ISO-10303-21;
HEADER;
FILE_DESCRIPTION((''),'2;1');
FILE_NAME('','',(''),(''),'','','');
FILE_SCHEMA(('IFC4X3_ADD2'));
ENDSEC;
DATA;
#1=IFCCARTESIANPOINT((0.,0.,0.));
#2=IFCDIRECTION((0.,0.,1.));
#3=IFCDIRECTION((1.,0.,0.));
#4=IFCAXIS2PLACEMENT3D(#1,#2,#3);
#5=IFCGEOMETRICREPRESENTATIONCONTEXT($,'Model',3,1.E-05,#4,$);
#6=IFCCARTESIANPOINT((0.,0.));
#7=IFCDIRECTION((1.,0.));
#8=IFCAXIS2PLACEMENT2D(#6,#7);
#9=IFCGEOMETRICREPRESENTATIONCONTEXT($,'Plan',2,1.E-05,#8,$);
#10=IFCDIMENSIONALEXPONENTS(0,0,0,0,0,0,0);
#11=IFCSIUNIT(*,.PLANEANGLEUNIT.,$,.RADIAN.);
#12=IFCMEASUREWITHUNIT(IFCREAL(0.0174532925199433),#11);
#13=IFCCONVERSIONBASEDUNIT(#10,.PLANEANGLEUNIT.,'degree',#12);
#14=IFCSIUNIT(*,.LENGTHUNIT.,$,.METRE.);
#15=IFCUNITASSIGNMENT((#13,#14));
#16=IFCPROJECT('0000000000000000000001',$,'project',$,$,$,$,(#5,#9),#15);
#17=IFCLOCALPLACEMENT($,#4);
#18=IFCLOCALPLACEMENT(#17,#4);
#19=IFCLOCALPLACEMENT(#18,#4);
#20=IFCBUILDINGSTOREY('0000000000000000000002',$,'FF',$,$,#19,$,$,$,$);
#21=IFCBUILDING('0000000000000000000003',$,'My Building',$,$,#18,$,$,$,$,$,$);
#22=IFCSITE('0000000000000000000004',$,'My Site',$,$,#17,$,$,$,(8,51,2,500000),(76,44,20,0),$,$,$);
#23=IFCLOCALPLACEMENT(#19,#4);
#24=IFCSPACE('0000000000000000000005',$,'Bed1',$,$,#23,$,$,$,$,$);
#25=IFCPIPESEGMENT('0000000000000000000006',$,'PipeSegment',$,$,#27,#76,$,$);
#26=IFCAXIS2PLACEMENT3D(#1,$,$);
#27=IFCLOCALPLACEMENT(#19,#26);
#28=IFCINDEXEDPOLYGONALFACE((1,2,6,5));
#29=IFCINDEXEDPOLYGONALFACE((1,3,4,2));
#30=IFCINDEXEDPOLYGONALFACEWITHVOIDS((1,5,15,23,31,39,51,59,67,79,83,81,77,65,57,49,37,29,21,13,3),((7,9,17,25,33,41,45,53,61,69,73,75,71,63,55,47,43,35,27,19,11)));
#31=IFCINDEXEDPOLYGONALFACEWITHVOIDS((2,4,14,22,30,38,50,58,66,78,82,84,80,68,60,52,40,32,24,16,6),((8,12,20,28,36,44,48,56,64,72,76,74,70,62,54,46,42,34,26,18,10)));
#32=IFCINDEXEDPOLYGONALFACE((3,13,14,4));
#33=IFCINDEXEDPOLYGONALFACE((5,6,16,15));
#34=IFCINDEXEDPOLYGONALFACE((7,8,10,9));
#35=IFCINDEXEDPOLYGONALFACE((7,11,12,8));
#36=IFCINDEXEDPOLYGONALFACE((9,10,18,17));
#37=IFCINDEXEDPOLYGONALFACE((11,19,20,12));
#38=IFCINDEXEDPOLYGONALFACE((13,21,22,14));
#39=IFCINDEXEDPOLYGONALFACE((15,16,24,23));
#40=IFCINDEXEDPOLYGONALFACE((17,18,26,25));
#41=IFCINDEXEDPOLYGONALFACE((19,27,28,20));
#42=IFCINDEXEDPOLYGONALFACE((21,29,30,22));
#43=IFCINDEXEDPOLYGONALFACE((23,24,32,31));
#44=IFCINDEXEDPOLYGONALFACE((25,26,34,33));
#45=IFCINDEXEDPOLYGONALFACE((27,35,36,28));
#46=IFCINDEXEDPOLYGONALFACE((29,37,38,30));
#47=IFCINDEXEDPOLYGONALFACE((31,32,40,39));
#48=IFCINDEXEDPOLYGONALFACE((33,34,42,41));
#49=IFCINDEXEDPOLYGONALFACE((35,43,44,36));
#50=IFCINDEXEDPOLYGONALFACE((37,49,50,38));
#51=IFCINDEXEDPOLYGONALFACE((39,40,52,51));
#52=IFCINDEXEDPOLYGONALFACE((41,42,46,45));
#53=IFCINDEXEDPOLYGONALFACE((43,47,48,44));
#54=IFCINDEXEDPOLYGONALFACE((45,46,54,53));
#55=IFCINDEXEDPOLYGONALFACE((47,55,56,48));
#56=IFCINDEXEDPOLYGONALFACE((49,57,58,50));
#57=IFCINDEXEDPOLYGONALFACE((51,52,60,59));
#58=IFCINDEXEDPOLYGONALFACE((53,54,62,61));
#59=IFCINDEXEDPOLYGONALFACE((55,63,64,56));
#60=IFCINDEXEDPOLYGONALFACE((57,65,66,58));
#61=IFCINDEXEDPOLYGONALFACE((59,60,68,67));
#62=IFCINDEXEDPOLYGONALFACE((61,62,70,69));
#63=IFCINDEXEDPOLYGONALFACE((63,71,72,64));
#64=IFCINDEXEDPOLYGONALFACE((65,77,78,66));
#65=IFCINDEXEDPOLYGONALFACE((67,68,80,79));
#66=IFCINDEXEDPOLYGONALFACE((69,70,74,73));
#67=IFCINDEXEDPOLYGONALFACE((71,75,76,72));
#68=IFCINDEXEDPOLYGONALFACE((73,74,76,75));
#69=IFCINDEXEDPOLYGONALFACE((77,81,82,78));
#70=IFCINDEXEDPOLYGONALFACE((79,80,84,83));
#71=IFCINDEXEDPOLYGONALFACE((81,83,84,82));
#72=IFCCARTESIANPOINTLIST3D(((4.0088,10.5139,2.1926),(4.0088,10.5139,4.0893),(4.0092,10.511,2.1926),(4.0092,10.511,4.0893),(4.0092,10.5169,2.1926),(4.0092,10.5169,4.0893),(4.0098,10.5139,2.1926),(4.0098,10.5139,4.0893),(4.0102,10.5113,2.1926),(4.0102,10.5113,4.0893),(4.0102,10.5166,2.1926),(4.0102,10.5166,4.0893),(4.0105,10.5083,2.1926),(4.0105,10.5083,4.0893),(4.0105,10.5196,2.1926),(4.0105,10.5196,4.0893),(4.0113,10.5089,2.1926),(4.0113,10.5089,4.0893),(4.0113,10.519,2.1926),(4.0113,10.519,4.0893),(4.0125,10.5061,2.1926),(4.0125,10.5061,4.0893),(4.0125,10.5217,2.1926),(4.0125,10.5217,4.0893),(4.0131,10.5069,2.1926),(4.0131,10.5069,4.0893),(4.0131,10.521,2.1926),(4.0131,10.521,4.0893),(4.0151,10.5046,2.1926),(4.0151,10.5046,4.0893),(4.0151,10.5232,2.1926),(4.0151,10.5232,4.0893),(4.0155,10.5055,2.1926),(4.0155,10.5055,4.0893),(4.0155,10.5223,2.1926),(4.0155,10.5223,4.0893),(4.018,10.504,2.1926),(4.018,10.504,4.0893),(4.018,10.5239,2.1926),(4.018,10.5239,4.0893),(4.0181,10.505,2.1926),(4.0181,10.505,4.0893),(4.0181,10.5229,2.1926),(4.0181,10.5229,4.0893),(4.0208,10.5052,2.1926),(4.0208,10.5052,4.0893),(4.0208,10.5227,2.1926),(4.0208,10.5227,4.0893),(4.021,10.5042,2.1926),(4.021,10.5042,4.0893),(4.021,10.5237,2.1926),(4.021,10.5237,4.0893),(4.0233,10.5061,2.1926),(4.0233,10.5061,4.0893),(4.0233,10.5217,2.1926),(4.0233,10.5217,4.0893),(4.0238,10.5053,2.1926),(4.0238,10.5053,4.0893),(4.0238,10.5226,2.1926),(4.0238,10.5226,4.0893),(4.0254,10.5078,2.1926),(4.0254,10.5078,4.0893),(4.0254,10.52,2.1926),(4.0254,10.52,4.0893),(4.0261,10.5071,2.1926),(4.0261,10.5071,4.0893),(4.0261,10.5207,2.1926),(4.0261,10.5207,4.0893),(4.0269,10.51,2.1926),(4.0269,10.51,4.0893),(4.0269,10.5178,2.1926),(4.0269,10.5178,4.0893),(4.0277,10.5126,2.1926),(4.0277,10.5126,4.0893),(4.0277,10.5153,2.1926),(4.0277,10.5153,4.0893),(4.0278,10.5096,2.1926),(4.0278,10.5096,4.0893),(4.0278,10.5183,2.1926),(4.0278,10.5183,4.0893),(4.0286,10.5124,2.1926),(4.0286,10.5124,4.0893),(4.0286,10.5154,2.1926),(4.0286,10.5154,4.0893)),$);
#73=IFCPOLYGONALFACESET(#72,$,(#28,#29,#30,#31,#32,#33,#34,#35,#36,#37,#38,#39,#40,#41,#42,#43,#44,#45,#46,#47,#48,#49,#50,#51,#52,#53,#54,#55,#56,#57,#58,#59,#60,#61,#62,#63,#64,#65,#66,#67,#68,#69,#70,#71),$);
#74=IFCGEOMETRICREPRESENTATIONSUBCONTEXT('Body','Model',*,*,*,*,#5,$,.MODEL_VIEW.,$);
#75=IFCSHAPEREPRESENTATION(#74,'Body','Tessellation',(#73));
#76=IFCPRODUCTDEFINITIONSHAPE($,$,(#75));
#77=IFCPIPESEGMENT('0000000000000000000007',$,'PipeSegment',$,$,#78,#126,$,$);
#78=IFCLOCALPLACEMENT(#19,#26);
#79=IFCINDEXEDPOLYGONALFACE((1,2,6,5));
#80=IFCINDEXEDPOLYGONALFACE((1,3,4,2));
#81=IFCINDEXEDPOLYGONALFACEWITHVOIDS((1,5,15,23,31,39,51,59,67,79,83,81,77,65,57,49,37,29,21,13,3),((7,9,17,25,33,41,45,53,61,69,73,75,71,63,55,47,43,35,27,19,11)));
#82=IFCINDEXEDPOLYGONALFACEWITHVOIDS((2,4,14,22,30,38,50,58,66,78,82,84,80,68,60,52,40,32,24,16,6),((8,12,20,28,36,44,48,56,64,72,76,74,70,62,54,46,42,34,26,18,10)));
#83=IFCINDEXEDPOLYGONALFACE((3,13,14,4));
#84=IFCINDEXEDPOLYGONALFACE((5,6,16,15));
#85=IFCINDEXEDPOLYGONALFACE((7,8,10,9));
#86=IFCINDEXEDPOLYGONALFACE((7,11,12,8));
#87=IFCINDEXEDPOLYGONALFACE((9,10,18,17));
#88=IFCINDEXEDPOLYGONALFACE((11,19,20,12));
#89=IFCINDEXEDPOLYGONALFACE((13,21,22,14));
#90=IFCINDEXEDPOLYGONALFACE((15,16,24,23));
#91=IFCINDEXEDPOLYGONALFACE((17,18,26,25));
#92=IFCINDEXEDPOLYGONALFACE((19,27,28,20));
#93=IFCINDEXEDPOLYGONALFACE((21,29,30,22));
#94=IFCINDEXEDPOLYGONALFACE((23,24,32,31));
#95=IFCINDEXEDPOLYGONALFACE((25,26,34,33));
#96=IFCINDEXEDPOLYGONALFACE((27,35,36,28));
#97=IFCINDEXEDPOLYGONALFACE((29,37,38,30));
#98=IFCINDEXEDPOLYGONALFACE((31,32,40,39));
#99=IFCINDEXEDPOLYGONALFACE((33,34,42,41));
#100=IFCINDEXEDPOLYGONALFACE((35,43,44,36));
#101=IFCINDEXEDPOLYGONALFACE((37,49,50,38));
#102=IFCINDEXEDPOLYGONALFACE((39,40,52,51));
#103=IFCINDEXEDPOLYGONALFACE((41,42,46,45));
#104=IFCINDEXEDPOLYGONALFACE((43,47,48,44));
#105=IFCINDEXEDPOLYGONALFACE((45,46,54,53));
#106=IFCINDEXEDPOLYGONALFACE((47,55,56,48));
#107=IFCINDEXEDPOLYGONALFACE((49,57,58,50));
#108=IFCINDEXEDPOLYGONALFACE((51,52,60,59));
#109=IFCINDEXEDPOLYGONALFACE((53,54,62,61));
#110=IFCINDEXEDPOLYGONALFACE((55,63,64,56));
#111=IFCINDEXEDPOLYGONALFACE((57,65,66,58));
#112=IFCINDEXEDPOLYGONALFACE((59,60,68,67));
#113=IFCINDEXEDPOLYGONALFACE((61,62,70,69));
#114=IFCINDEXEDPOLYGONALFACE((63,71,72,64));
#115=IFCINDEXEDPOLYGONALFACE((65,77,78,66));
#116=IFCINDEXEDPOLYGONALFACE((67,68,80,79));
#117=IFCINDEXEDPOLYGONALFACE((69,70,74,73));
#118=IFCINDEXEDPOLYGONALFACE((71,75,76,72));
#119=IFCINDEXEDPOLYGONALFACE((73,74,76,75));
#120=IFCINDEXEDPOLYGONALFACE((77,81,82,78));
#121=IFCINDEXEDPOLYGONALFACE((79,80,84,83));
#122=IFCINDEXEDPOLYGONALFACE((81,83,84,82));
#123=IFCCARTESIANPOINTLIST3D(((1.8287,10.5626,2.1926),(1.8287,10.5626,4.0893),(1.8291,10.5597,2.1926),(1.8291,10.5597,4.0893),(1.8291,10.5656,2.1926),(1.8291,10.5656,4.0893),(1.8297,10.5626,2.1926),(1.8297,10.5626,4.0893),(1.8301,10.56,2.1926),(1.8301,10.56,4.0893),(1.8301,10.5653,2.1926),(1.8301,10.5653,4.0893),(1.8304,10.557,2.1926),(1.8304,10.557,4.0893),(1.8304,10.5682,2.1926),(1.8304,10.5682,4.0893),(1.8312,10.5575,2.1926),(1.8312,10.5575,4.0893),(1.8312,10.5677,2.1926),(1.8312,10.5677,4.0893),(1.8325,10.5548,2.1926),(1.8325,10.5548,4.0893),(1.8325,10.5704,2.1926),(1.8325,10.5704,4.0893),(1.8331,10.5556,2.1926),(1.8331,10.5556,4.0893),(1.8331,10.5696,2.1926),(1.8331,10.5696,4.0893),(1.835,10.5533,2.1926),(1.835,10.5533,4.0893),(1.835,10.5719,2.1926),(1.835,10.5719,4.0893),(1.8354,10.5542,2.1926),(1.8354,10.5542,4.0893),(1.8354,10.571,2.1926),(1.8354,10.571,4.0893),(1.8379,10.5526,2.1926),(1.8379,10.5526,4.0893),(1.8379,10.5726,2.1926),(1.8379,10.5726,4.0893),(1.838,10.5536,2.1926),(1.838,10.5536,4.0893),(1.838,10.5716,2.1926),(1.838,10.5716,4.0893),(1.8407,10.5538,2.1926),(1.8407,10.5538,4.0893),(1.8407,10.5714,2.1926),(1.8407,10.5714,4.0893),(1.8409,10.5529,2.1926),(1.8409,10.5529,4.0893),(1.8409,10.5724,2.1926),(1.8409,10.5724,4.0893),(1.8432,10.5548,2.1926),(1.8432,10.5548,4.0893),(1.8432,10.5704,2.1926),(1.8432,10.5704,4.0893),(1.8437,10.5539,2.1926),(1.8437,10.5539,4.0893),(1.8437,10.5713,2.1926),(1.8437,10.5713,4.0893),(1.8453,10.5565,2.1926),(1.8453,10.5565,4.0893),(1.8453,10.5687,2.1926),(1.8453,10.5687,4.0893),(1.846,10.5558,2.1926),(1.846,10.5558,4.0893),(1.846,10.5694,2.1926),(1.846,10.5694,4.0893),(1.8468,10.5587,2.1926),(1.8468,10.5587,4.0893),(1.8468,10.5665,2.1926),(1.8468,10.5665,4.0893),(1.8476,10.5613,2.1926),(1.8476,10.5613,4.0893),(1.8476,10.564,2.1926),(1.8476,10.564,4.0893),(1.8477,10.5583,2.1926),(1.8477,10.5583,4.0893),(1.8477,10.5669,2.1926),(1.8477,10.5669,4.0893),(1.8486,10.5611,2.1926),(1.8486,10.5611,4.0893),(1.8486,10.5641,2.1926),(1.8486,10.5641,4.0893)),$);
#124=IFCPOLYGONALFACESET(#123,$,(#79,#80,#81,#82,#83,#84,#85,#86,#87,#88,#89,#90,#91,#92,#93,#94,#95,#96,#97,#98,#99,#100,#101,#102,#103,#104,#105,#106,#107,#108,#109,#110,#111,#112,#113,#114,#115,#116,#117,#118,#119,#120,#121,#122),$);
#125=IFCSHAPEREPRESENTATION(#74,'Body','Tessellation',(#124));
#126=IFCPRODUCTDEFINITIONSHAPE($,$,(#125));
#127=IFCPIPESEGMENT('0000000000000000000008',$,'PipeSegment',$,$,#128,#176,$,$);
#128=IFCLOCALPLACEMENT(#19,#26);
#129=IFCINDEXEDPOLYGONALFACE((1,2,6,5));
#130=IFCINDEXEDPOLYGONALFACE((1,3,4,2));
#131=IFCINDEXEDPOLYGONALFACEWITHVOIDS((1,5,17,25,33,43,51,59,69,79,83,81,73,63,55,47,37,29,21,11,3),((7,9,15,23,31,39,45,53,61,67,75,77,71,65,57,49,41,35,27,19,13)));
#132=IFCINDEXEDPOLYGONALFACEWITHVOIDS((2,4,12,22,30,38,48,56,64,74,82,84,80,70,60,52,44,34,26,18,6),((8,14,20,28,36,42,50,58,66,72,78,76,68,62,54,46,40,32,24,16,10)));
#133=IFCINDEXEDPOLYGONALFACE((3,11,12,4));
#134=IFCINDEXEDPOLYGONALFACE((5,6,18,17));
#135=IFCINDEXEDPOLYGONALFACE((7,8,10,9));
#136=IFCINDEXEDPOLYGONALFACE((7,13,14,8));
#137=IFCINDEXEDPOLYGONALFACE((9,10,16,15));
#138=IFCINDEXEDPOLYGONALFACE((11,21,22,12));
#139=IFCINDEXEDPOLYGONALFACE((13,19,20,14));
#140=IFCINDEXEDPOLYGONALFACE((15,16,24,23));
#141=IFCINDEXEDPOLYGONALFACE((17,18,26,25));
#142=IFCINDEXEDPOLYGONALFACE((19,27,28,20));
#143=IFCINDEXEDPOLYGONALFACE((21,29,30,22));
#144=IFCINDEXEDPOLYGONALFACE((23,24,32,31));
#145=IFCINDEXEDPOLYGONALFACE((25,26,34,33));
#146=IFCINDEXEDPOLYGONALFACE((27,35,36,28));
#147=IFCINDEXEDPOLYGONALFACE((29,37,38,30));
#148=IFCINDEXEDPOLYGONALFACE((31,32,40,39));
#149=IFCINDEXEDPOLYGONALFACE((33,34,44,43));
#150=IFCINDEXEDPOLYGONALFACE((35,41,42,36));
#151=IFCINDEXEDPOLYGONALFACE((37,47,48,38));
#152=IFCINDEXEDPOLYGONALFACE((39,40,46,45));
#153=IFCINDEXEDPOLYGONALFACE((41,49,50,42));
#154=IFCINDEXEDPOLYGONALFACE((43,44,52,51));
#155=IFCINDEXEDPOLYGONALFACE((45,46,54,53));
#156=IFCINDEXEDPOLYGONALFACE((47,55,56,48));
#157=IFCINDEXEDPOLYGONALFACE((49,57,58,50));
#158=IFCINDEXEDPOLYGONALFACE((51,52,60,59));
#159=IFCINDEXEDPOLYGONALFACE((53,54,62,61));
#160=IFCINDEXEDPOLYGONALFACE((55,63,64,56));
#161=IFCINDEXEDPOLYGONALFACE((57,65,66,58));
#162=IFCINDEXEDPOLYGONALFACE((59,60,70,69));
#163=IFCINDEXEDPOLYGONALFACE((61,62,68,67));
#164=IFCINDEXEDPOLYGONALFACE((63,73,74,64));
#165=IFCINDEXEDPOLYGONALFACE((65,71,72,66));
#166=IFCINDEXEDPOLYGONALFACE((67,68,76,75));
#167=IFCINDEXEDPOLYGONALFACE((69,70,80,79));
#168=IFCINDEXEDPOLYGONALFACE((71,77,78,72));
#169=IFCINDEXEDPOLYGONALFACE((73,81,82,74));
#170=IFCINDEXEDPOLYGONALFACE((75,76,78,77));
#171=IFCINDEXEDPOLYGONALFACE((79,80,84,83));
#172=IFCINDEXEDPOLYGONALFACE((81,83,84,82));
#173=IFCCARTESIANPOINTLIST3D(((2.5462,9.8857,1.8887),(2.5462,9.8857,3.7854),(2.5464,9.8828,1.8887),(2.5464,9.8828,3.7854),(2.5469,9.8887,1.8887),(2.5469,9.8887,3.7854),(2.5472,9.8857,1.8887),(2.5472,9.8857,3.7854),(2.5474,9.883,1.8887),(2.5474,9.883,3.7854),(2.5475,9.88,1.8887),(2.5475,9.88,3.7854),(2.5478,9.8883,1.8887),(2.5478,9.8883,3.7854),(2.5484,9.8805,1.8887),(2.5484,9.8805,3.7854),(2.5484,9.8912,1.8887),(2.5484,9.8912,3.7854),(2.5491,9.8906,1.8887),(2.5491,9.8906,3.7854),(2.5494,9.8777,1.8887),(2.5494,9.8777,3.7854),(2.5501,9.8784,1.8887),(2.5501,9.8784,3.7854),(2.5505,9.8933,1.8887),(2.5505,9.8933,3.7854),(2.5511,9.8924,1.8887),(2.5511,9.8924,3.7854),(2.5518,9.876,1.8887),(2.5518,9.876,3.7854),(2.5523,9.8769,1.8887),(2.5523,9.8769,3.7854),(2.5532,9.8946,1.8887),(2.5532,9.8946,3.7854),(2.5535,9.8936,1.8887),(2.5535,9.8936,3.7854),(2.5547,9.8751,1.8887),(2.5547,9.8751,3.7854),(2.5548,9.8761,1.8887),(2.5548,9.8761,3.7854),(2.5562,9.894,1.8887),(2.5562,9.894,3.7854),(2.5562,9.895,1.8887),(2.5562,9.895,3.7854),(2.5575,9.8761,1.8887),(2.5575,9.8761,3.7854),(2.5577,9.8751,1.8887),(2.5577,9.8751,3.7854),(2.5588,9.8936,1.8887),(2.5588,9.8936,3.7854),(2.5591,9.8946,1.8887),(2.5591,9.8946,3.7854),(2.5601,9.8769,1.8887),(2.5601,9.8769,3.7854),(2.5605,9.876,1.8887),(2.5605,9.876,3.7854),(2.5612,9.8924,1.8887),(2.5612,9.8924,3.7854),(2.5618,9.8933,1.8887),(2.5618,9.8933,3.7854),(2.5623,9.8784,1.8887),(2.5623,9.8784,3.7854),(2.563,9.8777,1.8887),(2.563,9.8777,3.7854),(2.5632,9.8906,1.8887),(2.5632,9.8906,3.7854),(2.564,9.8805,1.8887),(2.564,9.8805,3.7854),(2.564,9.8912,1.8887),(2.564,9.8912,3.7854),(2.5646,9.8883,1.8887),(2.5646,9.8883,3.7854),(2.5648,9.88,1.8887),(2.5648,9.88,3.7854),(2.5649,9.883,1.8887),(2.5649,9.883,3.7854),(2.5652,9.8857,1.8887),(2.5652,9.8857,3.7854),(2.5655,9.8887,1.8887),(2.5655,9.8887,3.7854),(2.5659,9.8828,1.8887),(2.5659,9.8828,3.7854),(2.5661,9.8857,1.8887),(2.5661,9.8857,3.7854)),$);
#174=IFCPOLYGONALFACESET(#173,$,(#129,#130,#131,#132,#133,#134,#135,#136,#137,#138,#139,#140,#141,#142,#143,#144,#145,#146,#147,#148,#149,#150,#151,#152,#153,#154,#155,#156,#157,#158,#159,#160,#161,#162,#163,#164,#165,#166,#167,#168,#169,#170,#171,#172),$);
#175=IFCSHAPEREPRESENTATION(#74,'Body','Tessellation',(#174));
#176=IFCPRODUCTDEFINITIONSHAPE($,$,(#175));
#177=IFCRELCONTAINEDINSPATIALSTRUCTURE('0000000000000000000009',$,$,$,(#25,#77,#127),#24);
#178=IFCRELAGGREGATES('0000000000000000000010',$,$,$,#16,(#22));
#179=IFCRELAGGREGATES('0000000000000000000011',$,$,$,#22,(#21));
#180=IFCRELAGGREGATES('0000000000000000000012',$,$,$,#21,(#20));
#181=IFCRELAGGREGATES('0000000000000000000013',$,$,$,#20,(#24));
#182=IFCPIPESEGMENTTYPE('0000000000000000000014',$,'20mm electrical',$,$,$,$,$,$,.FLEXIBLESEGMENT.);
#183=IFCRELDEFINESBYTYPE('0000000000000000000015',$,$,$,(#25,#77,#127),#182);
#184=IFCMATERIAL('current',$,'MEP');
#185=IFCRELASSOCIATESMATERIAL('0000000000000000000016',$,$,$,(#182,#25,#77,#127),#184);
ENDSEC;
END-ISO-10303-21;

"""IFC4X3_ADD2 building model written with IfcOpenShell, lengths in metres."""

from ifc_helpers import new_model, entity, si_unit, converted_unit, frame, origin_with_axes, origin_2d_with_axis, place, context, subcontext, project, spatial, hollow_circle, extrude, material, material_profile, profile_set, profile_usage, type_object, element, save


model = new_model("IFC4X3_ADD2")

# Units and contexts
model_context = context("Model", 3, precision=1e-05, world=origin_with_axes())
plan_context = context("Plan", 2, precision=1e-05, world=origin_2d_with_axis())
body_context = subcontext(model_context, "Body", "Model", "MODEL_VIEW")
ifc_project = project(units=[converted_unit("PLANEANGLEUNIT", "degree", entity("IfcReal", 0.0174532925199433), si_unit("PLANEANGLEUNIT", "RADIAN"), dimensions=[0, 0, 0, 0, 0, 0, 0]), si_unit("LENGTHUNIT", "METRE")], contexts=[model_context, plan_context])

# Site, building, storey
site_placement = place(None, origin_with_axes())
site = spatial("IfcSite", under=ifc_project, at=site_placement, Name="My Site", RefLatitude=(8, 51, 2, 500000), RefLongitude=(76, 44, 20, 0))
building_placement = place(site_placement, origin_with_axes())
building = spatial("IfcBuilding", under=site, at=building_placement, Name="My Building")
storey_placement = place(building_placement, origin_with_axes())
storey = spatial("IfcBuildingStorey", under=building, at=storey_placement, Name="FF")

# Shared definitions
space_placement = place(storey_placement, origin_with_axes())
space = spatial("IfcSpace", under=storey, at=space_placement, Name="Bed1")

# Pipe segments
ifc_material_1 = material(Name="current", Category="MEP")
ifc_material_profile = material_profile(ifc_material_1, hollow_circle(Radius=0.01, WallThickness=0.001))
ifc_profile_set = profile_set([ifc_material_profile], Name="current")
pipe_segment_type = type_object("IfcPipeSegmentType", Name="20mm electrical", PredefinedType="FLEXIBLESEGMENT", material=ifc_profile_set)
ifc_profile_usage_1 = profile_usage(ifc_profile_set, cardinal=5)
pipe_segment_1_placement = place(space_placement, frame((4.0188, 10.5139, 2.1926), z_axis=(0.0, 0.0, 1.0), x_axis=(-1.0, 0.0, 0.0)))
element("IfcPipeSegment", 1, at=pipe_segment_1_placement, inside=space, type_object=pipe_segment_type, material=ifc_profile_usage_1, Name="PipeSegment", context=body_context, shape_type="SweptSolid", body=[
    extrude(hollow_circle(Radius=0.01, WallThickness=0.001), origin_with_axes(), (0.0, 0.0, 1.0), 1.8967),
])
ifc_profile_usage_2 = profile_usage(ifc_profile_set, cardinal=5)
pipe_segment_2_placement = place(space_placement, frame((1.8387, 10.5626, 2.1926), z_axis=(0.0, 0.0, 1.0), x_axis=(-1.0, 0.0, 0.0)))
element("IfcPipeSegment", 2, at=pipe_segment_2_placement, inside=space, type_object=pipe_segment_type, material=ifc_profile_usage_2, Name="PipeSegment", context=body_context, shape_type="SweptSolid", body=[
    extrude(hollow_circle(Radius=0.01, WallThickness=0.001), origin_with_axes(), (0.0, 0.0, 1.0), 1.8967),
])
ifc_profile_usage_3 = profile_usage(ifc_profile_set, cardinal=5)
pipe_segment_3_placement = place(space_placement, frame((2.5562, 9.885, 1.8887), z_axis=(0.0, 0.0, 1.0), x_axis=(0.0, 1.0, 0.0)))
element("IfcPipeSegment", 3, at=pipe_segment_3_placement, inside=space, type_object=pipe_segment_type, material=ifc_profile_usage_3, Name="PipeSegment", context=body_context, shape_type="SweptSolid", body=[
    extrude(hollow_circle(Radius=0.01, WallThickness=0.001), origin_with_axes(), (0.0, 0.0, 1.0), 1.8967),
])

save(model, "model.ifc")
